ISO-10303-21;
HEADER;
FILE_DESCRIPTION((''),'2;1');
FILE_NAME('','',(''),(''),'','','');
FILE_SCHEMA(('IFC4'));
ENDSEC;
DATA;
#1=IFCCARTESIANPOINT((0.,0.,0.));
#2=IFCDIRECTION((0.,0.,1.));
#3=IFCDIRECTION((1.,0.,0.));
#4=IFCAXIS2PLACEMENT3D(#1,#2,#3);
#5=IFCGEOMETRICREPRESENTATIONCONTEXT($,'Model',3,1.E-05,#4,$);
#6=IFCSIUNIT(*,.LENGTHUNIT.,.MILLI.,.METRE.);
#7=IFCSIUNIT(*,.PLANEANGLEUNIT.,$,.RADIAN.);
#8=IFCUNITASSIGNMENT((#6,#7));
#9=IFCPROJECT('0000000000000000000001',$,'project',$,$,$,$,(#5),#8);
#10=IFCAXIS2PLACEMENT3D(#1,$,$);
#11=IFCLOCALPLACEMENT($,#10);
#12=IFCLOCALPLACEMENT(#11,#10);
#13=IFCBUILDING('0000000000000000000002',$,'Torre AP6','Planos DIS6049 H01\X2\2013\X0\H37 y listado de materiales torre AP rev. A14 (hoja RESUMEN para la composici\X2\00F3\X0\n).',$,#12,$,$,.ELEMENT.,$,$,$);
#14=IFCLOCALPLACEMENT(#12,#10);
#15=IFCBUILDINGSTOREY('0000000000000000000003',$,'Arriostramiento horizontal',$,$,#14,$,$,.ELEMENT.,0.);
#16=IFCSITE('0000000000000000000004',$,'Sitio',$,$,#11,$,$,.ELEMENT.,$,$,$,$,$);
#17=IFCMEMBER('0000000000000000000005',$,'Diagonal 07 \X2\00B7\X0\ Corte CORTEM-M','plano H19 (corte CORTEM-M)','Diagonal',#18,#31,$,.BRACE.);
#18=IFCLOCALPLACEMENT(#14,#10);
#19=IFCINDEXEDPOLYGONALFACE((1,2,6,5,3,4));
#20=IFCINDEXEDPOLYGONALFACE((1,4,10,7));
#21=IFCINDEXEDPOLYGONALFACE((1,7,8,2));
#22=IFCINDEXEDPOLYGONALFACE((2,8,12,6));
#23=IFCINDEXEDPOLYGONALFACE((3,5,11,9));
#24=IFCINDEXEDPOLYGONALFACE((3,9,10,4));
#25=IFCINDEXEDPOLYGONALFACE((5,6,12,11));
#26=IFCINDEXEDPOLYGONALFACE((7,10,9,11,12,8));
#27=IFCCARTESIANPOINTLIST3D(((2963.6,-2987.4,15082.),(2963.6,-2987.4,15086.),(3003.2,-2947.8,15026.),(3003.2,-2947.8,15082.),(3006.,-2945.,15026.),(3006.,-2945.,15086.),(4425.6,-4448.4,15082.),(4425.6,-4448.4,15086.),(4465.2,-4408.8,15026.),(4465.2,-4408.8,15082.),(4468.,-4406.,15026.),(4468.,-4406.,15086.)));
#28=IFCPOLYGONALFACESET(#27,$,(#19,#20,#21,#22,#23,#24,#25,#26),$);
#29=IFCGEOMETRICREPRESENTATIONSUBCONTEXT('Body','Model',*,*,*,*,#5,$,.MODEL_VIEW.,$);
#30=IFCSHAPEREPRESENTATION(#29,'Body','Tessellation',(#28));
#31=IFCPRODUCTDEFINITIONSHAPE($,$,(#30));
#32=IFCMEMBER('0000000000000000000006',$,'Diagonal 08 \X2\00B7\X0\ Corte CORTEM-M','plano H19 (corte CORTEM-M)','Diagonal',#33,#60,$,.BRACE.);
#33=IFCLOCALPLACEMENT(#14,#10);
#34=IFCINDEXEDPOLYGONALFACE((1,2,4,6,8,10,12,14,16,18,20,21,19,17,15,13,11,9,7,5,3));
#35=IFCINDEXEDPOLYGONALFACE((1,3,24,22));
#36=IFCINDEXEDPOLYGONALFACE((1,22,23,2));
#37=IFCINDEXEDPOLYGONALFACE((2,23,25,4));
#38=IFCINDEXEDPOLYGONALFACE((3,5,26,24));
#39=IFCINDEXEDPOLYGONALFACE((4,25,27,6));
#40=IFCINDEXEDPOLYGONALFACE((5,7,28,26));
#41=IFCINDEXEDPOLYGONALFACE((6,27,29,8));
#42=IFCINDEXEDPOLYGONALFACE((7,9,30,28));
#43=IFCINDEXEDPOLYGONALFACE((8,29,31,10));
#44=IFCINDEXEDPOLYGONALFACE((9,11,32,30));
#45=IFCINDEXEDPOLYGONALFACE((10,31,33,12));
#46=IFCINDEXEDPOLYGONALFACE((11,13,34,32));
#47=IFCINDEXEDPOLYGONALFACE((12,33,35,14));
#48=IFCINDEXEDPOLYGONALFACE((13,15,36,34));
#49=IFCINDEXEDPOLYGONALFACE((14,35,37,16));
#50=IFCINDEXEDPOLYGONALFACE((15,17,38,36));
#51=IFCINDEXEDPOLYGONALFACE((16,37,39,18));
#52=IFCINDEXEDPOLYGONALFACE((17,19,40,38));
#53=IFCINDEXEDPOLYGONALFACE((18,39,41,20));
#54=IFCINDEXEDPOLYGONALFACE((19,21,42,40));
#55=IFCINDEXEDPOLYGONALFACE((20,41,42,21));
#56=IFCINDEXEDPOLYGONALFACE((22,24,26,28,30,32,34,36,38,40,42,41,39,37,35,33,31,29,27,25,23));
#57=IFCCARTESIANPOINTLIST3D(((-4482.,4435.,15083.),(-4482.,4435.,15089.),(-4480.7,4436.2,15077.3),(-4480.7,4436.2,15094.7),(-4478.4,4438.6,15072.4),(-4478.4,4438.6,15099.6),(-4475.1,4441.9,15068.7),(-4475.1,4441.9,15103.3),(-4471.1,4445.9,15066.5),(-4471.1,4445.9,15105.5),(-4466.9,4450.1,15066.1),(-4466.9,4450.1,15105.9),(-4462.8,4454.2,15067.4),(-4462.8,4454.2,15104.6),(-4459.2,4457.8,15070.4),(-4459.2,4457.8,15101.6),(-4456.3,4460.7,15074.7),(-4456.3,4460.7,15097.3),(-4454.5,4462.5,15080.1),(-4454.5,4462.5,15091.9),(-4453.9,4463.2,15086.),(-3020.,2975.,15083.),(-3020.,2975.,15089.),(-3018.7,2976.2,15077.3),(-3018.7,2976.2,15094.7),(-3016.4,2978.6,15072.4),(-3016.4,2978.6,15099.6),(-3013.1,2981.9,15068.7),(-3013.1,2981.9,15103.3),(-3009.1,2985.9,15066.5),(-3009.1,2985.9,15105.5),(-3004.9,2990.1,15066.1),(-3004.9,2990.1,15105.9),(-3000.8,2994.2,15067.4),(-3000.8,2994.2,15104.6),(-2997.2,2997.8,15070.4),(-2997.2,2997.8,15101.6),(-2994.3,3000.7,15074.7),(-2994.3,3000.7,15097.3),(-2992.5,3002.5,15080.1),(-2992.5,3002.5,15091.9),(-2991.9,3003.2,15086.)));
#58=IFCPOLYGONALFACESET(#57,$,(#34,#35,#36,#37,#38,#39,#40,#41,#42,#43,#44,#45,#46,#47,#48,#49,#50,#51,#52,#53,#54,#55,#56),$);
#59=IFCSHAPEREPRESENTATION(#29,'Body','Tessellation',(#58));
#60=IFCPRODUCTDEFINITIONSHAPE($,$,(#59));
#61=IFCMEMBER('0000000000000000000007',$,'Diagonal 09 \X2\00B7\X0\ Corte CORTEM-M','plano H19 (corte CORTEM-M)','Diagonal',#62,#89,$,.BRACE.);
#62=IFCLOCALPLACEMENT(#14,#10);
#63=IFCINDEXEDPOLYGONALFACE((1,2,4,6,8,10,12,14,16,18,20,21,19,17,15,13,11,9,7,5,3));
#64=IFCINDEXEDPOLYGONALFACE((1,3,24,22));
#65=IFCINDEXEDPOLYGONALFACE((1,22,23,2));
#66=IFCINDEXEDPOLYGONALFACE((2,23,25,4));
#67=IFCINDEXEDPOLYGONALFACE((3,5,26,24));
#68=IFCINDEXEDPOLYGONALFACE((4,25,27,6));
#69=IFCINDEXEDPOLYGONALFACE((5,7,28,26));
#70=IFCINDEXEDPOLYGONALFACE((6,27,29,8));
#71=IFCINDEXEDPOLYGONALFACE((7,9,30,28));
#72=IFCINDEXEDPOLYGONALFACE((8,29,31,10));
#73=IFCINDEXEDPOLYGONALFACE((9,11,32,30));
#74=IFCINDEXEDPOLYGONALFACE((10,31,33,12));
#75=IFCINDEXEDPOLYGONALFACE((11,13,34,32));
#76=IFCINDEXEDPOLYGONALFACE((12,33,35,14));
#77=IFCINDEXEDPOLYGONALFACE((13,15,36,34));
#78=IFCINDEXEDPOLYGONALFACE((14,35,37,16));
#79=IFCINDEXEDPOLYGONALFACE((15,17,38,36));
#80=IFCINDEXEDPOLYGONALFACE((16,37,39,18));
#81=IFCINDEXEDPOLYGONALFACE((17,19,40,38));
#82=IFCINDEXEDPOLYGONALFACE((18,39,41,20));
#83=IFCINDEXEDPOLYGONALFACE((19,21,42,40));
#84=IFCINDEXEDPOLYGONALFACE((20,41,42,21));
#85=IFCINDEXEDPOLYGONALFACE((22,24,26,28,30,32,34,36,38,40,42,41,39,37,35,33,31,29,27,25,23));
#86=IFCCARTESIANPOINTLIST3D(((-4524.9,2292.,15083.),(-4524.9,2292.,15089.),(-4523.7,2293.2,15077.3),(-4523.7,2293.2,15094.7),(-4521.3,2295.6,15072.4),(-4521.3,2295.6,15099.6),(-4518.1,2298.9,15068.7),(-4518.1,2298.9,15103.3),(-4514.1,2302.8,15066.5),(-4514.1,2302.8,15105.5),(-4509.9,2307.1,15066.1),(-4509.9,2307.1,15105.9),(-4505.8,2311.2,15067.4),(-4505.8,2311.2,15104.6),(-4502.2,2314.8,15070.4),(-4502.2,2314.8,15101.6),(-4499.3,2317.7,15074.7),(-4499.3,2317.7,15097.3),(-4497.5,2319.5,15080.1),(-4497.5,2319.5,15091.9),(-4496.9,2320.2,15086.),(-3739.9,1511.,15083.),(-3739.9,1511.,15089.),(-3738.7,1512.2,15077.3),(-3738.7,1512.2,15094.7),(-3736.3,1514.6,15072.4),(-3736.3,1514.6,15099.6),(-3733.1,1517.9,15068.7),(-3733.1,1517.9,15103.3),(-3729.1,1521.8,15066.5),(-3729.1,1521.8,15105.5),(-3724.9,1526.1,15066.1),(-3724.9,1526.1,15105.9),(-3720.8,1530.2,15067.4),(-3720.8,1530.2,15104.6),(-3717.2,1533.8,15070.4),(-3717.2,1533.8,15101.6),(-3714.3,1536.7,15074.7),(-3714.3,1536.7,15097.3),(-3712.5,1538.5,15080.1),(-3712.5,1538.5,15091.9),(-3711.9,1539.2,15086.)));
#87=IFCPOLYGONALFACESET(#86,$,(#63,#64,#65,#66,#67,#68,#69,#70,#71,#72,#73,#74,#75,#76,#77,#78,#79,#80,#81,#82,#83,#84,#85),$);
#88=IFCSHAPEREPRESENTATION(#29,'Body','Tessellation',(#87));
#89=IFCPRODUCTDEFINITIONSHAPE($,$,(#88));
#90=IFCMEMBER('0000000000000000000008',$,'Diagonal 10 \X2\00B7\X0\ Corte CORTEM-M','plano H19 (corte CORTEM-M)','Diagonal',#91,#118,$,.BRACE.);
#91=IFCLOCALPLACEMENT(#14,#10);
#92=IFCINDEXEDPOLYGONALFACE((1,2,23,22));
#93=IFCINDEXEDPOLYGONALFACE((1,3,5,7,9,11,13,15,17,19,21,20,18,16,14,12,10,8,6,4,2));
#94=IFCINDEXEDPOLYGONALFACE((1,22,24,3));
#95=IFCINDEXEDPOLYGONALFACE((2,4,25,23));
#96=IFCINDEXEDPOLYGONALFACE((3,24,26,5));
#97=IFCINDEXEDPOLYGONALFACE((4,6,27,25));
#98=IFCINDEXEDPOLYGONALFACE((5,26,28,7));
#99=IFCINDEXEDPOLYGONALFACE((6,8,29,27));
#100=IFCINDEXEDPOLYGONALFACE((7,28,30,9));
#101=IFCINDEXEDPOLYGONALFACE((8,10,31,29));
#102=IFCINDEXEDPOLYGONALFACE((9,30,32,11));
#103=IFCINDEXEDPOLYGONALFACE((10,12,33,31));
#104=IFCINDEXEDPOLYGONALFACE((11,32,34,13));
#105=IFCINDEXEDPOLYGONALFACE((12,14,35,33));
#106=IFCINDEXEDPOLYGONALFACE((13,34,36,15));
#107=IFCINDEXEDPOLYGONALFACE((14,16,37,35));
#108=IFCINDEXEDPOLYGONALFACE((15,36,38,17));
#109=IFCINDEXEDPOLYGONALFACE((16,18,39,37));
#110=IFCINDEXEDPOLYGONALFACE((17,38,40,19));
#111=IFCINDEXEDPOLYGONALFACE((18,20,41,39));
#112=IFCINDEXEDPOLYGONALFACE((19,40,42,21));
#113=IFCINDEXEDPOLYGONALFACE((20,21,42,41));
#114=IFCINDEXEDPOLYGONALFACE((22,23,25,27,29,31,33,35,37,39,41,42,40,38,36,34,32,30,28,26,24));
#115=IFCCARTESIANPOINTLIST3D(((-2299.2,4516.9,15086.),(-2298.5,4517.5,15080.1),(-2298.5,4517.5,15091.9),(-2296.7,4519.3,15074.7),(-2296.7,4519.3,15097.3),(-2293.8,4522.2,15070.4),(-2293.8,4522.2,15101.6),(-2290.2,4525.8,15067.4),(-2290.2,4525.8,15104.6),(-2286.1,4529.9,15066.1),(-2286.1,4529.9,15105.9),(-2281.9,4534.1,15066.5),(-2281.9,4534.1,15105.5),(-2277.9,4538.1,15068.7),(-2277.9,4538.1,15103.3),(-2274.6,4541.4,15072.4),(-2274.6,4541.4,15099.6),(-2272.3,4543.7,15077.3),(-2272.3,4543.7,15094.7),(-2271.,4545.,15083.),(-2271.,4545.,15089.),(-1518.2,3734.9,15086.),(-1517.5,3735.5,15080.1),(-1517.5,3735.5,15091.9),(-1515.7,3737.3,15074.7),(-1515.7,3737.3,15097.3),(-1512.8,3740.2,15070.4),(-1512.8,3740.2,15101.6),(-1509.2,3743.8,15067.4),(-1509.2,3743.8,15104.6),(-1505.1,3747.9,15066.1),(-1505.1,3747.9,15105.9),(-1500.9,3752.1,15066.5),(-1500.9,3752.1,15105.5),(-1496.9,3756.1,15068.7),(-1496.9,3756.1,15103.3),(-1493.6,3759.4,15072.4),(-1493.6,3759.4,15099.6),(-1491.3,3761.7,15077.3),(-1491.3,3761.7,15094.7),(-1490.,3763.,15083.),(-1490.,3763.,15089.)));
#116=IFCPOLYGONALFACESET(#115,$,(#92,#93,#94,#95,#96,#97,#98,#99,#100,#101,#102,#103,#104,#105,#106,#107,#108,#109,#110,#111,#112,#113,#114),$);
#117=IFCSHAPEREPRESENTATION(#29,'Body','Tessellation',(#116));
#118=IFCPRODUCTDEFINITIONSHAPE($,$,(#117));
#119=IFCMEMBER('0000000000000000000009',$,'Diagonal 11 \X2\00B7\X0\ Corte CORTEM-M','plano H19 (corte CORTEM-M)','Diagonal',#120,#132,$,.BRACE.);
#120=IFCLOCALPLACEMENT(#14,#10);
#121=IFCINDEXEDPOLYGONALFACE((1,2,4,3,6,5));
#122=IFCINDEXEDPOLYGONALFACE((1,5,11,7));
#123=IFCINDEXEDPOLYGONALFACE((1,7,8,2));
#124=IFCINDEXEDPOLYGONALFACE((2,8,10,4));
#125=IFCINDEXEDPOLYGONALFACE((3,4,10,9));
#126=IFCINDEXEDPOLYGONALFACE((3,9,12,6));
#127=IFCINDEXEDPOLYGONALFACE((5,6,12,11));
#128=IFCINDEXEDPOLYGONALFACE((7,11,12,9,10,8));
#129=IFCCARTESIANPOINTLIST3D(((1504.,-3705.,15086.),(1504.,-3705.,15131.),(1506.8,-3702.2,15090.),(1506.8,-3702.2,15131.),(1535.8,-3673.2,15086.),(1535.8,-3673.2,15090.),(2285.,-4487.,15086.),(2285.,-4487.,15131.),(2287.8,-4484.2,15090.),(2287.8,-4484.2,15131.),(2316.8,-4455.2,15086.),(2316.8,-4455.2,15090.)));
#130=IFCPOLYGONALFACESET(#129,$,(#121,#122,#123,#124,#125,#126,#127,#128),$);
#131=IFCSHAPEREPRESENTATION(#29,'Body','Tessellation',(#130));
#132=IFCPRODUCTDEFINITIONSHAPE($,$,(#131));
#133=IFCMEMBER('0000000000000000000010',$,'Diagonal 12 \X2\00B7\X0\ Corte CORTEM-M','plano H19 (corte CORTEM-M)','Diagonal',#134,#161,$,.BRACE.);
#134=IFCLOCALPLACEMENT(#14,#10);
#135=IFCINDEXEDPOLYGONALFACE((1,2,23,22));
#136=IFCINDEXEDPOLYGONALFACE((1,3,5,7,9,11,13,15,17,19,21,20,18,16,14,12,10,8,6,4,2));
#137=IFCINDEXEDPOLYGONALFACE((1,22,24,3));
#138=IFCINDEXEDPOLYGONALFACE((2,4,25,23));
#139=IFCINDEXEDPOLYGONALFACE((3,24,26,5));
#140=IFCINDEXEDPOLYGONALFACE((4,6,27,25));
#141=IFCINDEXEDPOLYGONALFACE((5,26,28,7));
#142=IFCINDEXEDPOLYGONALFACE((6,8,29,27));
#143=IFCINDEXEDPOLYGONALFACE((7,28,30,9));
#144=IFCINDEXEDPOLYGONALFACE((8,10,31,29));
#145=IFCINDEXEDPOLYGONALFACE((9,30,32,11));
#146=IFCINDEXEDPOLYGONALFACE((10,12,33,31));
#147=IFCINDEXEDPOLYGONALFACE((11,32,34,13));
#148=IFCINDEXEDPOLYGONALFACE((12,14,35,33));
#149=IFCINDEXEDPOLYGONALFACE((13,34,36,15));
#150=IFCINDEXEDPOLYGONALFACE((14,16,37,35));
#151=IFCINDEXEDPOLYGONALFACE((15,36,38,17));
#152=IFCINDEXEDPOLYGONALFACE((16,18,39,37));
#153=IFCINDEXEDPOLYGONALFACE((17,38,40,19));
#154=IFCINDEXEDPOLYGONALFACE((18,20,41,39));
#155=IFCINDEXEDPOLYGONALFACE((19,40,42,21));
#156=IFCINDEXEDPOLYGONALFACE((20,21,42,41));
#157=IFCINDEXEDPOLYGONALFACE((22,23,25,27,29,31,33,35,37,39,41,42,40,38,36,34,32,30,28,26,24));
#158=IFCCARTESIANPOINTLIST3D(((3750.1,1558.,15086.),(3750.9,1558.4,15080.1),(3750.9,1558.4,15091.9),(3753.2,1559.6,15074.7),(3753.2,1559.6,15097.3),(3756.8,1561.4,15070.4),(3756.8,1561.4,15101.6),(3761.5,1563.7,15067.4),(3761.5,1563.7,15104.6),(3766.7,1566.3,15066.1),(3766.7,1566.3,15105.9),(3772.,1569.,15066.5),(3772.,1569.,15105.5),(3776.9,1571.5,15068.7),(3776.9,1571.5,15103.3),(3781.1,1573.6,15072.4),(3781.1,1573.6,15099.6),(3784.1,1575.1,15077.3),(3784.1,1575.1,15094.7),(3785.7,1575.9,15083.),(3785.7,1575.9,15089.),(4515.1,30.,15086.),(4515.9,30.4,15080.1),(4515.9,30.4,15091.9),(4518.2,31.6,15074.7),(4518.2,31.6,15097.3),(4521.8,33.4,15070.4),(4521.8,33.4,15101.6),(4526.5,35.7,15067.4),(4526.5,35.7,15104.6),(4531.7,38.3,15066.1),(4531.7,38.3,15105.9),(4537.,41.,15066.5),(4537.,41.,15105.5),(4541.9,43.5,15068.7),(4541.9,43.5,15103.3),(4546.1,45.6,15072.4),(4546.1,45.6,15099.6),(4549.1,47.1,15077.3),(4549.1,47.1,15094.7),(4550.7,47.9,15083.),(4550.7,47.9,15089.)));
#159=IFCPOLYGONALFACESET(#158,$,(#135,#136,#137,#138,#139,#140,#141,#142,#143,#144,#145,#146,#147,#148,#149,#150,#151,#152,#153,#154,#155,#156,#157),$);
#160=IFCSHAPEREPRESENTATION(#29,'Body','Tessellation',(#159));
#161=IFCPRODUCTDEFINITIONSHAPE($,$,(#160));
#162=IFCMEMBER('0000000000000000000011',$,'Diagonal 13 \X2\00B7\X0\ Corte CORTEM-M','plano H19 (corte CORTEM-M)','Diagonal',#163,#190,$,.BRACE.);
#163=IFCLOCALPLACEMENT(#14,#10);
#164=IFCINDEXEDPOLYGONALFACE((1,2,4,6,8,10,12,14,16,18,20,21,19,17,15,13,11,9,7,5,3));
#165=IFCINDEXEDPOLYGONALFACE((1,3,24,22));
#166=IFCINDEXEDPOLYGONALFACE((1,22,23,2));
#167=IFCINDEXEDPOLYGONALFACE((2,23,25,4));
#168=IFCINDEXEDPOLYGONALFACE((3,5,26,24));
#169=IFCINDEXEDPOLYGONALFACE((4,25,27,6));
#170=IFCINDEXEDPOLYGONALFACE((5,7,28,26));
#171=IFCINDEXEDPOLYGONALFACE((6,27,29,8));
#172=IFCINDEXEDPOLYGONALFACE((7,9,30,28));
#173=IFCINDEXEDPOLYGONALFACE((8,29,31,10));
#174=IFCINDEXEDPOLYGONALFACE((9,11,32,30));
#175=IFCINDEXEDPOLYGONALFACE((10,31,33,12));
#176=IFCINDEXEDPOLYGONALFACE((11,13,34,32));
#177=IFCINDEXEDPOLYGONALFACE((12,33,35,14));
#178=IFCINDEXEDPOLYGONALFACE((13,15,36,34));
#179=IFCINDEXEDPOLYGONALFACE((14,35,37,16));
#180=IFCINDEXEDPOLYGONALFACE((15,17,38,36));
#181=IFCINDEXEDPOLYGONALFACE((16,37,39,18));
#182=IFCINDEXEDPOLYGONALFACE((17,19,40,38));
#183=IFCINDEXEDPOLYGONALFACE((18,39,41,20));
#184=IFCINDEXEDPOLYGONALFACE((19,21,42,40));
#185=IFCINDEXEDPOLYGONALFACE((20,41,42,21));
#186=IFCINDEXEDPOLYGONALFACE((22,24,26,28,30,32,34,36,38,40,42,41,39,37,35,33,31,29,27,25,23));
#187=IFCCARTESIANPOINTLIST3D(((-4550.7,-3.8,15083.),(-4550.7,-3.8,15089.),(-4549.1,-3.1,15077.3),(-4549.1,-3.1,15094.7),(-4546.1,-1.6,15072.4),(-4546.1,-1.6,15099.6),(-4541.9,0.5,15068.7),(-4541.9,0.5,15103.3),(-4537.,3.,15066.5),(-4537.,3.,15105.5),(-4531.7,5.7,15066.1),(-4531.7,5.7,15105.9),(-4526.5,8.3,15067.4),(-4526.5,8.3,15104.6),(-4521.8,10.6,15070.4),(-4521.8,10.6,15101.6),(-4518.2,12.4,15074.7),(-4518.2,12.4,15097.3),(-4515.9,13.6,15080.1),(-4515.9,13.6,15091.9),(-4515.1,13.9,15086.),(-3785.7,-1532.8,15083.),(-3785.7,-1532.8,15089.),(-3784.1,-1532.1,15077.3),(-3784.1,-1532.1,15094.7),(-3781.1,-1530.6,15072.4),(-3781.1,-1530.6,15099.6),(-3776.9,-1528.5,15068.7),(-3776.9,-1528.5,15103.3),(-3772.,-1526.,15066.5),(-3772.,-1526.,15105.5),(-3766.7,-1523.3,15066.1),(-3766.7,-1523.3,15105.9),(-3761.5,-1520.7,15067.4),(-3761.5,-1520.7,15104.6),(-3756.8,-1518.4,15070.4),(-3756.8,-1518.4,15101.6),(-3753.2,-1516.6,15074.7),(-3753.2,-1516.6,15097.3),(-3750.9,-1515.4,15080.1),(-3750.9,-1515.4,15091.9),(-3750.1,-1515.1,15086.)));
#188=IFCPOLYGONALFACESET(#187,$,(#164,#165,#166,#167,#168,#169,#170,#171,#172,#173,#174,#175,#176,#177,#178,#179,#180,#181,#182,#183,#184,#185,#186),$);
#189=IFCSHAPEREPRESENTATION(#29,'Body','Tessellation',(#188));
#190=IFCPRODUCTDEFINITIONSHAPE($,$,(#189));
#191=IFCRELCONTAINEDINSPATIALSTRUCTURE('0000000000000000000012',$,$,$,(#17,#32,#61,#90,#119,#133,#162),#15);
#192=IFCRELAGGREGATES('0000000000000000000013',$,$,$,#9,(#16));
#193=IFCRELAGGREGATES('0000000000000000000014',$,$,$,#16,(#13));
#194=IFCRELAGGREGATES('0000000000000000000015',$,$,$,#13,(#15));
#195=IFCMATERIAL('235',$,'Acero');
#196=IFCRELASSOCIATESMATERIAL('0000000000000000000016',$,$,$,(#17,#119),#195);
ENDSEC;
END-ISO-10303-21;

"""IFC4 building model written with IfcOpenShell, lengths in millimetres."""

from ifc_helpers import new_model, si_unit, frame, frame_2d, origin, origin_with_axes, place, context, subcontext, project, spatial, circle, l_section, extrude, material, element, save


model = new_model("IFC4")

# Units and contexts
model_context = context("Model", 3, precision=1e-05, world=origin_with_axes())
body_context = subcontext(model_context, "Body", "Model", "MODEL_VIEW")
ifc_project = project(units=[si_unit("LENGTHUNIT", "METRE", prefix="MILLI"), si_unit("PLANEANGLEUNIT", "RADIAN")], contexts=[model_context])

# Site, building, storey
site_placement = place(None, origin())
site = spatial("IfcSite", under=ifc_project, at=site_placement, Name="Sitio", CompositionType="ELEMENT")
building_placement = place(site_placement, origin())
building = spatial("IfcBuilding", under=site, at=building_placement, Name="Torre AP6", Description="Planos DIS6049 H01–H37 y listado de materiales torre AP rev. A14 (hoja RESUMEN para la composición).", CompositionType="ELEMENT")
storey_placement = place(building_placement, origin())
storey = spatial("IfcBuildingStorey", under=building, at=storey_placement, Name="Arriostramiento horizontal", CompositionType="ELEMENT", Elevation=0.0)

# Members
ifc_material = material(Name="235", Category="Acero")
member_1_placement = place(storey_placement, frame((3006.0, -2945.0, 15086.0), z_axis=(0.707349, -0.706865, 0.0), x_axis=(-0.706865, -0.707349, 0.0)))
element("IfcMember", 1, at=member_1_placement, inside=storey, material=ifc_material, Name="Diagonal 07 · Corte CORTEM-M", Description="plano H19 (corte CORTEM-M)", ObjectType="Diagonal", PredefinedType="BRACE", context=body_context, shape_type="SweptSolid", body=[
    extrude(l_section(Depth=60.0, Width=60.0, Thickness=4.0, at=frame_2d((30.0, 30.0))), None, (0.0, 0.0, 1.0), 2066.9),
])
member_2_placement = place(storey_placement, frame((-4468.0, 4449.0, 15086.0), z_axis=(0.707591, -0.706623, 0.0), x_axis=(0.706623, 0.707591, 0.0)))
element("IfcMember", 2, at=member_2_placement, inside=storey, Name="Diagonal 08 · Corte CORTEM-M", Description="plano H19 (corte CORTEM-M)", ObjectType="Diagonal", PredefinedType="BRACE", context=body_context, shape_type="SweptSolid", body=[
    extrude(circle(Radius=20.0), None, (0.0, 0.0, 1.0), 2066.2),
])
member_3_placement = place(storey_placement, frame((-4511.0, 2306.0, 15086.0), z_axis=(0.708911, -0.705298, 0.0), x_axis=(0.705298, 0.708911, 0.0)))
element("IfcMember", 3, at=member_3_placement, inside=storey, Name="Diagonal 09 · Corte CORTEM-M", Description="plano H19 (corte CORTEM-M)", ObjectType="Diagonal", PredefinedType="BRACE", context=body_context, shape_type="SweptSolid", body=[
    extrude(circle(Radius=20.0), None, (0.0, 0.0, 1.0), 1107.3),
])
member_4_placement = place(storey_placement, frame((-2285.0, 4531.0, 15086.0), z_axis=(0.706654, -0.707559, 0.0), x_axis=(-0.707559, -0.706654, 0.0)))
element("IfcMember", 4, at=member_4_placement, inside=storey, Name="Diagonal 10 · Corte CORTEM-M", Description="plano H19 (corte CORTEM-M)", ObjectType="Diagonal", PredefinedType="BRACE", context=body_context, shape_type="SweptSolid", body=[
    extrude(circle(Radius=20.0), None, (0.0, 0.0, 1.0), 1105.2),
])
member_5_placement = place(storey_placement, frame((1504.0, -3705.0, 15086.0), z_axis=(0.706654, -0.707559, 0.0), x_axis=(0.707559, 0.706654, 0.0)))
element("IfcMember", 5, at=member_5_placement, inside=storey, material=ifc_material, Name="Diagonal 11 · Corte CORTEM-M", Description="plano H19 (corte CORTEM-M)", ObjectType="Diagonal", PredefinedType="BRACE", context=body_context, shape_type="SweptSolid", body=[
    extrude(l_section(Depth=45.0, Width=45.0, Thickness=4.0, at=frame_2d((22.5, 22.5))), None, (0.0, 0.0, 1.0), 1105.2),
])
member_6_placement = place(storey_placement, frame((3768.0, 1567.0, 15086.0), z_axis=(0.447682, -0.894193, 0.0), x_axis=(-0.894193, -0.447682, 0.0)))
element("IfcMember", 6, at=member_6_placement, inside=storey, Name="Diagonal 12 · Corte CORTEM-M", Description="plano H19 (corte CORTEM-M)", ObjectType="Diagonal", PredefinedType="BRACE", context=body_context, shape_type="SweptSolid", body=[
    extrude(circle(Radius=20.0), None, (0.0, 0.0, 1.0), 1708.8),
])
member_7_placement = place(storey_placement, frame((-4533.0, 5.0, 15086.0), z_axis=(0.447448, -0.89431, 0.0), x_axis=(0.89431, 0.447448, 0.0)))
element("IfcMember", 7, at=member_7_placement, inside=storey, Name="Diagonal 13 · Corte CORTEM-M", Description="plano H19 (corte CORTEM-M)", ObjectType="Diagonal", PredefinedType="BRACE", context=body_context, shape_type="SweptSolid", body=[
    extrude(circle(Radius=20.0), None, (0.0, 0.0, 1.0), 1709.7),
])

save(model, "model.ifc")
